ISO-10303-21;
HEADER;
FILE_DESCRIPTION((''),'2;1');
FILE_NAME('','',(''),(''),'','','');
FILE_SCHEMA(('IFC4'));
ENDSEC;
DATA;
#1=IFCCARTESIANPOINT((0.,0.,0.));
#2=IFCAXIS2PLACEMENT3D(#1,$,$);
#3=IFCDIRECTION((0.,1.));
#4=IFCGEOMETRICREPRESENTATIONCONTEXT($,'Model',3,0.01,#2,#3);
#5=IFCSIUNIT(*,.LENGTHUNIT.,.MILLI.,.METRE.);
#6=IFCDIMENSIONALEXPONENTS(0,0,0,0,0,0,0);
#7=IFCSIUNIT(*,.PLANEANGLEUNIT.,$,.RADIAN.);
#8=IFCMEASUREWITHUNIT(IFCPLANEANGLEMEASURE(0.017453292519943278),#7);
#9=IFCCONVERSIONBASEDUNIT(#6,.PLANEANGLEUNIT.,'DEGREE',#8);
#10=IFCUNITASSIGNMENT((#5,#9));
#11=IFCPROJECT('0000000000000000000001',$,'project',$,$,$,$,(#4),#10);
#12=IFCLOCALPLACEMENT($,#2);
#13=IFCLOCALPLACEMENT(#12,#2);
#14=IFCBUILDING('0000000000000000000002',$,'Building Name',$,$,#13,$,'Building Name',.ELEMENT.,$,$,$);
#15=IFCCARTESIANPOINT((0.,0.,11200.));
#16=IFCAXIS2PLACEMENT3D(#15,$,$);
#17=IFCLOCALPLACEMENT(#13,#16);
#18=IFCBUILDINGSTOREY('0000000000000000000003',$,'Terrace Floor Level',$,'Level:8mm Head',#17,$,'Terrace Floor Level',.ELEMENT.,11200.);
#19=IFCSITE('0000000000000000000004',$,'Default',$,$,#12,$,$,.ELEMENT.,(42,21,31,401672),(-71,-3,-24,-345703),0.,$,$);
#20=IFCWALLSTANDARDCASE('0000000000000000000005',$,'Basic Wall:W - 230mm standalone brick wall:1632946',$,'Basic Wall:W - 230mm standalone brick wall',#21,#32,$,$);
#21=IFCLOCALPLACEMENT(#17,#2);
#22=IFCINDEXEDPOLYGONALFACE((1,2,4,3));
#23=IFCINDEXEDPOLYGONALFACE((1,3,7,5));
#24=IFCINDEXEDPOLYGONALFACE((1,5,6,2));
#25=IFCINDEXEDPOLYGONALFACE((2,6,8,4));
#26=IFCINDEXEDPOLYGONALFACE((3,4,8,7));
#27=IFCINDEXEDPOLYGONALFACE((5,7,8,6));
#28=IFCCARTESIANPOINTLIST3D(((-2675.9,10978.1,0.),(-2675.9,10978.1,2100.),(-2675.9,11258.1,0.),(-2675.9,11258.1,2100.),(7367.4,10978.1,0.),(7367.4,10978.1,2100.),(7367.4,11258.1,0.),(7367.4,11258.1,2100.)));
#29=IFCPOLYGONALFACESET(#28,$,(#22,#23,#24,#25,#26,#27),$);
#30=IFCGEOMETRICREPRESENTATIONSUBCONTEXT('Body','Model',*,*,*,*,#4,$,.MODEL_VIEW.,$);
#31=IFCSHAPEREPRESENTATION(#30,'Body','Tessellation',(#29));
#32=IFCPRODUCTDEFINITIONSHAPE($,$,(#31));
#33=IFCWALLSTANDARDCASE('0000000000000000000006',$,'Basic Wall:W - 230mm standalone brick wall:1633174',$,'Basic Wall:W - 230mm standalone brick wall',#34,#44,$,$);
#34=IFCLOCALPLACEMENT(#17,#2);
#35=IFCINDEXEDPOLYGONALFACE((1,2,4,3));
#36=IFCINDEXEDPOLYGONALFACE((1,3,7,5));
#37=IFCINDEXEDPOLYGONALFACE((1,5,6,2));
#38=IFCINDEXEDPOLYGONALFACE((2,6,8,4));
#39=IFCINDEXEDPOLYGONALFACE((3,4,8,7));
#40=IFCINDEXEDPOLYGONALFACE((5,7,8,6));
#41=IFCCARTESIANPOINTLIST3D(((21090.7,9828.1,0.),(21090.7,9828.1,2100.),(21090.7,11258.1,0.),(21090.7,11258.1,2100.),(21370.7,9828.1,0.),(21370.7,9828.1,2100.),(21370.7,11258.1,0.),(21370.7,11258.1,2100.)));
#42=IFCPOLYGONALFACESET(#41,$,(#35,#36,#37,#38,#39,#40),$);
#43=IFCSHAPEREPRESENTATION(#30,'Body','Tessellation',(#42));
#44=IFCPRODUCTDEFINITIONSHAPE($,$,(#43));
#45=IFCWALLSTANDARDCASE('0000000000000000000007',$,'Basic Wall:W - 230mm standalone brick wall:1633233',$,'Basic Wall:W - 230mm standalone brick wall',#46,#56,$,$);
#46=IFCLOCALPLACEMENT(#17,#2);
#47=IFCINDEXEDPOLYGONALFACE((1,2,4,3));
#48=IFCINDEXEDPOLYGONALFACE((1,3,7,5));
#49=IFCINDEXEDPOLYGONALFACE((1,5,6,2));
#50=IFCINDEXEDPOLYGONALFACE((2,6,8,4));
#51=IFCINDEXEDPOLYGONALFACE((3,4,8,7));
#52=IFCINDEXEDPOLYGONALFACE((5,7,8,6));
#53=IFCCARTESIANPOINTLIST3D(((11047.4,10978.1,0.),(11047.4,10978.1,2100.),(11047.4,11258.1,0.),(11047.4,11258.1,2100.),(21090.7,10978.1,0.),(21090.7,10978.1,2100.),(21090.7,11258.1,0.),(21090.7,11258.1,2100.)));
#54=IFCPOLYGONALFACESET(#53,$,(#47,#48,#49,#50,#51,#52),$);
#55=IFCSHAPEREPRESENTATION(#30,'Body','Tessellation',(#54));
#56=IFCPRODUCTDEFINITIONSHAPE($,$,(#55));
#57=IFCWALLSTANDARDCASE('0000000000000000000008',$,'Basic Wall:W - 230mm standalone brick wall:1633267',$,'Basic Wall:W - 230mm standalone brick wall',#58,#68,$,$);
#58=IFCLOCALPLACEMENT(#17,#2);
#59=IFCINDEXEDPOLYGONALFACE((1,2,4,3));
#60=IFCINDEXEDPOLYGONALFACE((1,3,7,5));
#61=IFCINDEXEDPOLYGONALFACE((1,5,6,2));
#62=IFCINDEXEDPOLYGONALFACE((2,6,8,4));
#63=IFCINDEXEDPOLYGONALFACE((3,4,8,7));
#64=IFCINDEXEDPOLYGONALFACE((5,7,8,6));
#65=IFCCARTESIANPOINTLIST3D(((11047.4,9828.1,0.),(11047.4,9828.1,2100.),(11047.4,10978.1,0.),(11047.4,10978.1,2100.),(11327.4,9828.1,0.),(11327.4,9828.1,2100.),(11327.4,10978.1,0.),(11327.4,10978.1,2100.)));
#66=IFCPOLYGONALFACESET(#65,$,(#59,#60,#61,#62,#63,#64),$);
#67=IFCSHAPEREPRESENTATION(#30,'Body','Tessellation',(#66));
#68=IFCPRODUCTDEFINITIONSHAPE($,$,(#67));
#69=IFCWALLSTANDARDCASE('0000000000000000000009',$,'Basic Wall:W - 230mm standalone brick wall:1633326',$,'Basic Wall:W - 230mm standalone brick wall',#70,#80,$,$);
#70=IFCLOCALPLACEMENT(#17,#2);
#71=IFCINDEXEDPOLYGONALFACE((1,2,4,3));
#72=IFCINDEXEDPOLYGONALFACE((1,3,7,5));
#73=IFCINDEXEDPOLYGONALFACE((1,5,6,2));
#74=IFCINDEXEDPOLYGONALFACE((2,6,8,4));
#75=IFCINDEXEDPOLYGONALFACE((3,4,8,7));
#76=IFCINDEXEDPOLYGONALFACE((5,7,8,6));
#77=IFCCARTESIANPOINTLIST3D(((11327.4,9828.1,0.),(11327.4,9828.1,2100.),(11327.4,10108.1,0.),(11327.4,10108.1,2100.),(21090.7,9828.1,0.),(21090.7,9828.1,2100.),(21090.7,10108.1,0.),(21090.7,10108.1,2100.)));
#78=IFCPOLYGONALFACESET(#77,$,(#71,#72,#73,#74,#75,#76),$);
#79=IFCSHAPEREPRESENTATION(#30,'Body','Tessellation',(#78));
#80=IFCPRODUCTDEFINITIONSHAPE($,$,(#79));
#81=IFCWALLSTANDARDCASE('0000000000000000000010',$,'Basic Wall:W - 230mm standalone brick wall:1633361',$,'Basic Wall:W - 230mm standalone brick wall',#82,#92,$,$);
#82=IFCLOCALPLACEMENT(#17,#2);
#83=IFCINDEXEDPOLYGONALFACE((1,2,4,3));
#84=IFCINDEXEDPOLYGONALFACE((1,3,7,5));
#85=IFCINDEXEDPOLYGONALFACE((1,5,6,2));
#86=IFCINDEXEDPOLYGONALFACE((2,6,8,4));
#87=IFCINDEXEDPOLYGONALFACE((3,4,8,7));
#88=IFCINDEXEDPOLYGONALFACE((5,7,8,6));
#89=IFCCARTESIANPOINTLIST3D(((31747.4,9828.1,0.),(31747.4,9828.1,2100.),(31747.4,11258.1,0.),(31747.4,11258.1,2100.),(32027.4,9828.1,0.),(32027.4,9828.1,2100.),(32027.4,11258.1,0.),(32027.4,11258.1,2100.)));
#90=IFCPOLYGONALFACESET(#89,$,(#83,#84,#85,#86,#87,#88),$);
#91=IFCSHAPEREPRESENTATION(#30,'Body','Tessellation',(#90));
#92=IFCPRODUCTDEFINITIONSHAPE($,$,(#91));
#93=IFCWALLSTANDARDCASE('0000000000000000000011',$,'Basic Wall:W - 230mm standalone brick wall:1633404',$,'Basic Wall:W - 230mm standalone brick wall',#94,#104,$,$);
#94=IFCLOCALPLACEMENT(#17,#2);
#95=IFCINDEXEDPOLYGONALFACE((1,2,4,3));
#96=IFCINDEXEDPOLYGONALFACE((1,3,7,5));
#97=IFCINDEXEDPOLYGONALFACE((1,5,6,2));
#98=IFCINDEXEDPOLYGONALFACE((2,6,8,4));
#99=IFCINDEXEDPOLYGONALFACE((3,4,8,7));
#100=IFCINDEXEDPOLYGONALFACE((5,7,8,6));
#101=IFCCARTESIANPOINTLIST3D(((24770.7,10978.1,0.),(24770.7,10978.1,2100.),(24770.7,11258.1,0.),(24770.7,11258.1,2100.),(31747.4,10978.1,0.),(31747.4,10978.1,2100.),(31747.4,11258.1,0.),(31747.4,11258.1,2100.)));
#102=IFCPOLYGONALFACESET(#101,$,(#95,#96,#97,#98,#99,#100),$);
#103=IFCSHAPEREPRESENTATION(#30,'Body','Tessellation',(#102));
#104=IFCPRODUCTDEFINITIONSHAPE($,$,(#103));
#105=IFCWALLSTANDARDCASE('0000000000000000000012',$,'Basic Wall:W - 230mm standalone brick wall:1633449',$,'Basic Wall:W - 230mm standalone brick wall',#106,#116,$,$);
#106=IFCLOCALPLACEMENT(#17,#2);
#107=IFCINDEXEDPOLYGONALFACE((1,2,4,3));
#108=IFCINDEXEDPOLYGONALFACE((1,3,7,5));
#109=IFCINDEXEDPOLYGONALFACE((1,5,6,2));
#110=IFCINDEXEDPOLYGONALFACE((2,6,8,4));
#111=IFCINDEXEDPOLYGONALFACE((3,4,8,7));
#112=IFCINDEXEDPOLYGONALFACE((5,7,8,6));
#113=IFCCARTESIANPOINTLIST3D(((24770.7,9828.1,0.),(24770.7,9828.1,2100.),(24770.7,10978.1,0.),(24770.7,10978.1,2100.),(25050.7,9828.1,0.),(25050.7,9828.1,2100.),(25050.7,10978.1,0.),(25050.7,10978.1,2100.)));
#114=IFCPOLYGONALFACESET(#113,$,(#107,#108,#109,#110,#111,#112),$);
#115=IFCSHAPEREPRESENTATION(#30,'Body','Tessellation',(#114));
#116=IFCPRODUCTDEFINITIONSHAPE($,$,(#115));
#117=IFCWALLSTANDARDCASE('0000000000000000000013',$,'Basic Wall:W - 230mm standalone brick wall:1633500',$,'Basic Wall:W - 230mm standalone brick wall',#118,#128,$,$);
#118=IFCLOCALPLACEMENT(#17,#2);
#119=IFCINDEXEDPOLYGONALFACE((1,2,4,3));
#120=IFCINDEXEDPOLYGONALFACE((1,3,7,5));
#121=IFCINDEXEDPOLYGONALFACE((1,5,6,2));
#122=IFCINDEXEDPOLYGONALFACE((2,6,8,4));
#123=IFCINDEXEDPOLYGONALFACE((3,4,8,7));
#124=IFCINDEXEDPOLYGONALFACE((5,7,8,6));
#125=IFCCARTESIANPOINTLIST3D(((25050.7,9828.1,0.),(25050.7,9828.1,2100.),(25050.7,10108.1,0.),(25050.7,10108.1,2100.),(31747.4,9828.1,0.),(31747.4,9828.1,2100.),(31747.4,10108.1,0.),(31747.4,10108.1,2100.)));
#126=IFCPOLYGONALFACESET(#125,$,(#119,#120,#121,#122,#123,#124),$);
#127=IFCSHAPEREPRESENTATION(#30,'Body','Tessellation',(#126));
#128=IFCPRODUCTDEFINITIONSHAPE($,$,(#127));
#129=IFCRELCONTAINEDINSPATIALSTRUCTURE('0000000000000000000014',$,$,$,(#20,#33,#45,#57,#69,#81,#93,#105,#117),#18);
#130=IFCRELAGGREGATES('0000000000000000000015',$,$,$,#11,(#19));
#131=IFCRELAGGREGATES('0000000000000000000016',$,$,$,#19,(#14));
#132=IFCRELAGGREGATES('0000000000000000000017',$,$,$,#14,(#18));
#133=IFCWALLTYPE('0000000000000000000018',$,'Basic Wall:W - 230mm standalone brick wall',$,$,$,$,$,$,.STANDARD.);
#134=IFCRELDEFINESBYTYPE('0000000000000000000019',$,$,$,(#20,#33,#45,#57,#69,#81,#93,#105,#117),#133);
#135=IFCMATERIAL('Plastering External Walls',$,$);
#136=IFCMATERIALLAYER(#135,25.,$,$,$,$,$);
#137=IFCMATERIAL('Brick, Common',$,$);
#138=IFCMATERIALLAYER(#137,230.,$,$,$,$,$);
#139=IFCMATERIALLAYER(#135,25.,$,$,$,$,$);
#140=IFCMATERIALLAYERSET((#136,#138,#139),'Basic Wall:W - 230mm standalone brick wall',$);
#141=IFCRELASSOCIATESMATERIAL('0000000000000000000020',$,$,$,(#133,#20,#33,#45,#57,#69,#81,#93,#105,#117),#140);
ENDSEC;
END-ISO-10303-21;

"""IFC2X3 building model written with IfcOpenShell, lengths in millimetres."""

from ifc_helpers import new_model, entity, si_unit, converted_unit, direction, frame, frame_2d, origin, place, context, subcontext, project, spatial, rectangle, extrude, material, layer, layer_set, layer_usage, type_object, element, save


model = new_model("IFC2X3")

# Units and contexts
model_context = context("Model", 3, precision=0.01, world=origin(), true_north=direction((0.0, 1.0)))
body_context = subcontext(model_context, "Body", "Model", "MODEL_VIEW")
ifc_project = project(units=[si_unit("LENGTHUNIT", "METRE", prefix="MILLI"), converted_unit("PLANEANGLEUNIT", "DEGREE", entity("IfcPlaneAngleMeasure", 0.017453292519943278), si_unit("PLANEANGLEUNIT", "RADIAN"), dimensions=[0, 0, 0, 0, 0, 0, 0])], contexts=[model_context])

# Site, building, storey
site_placement = place(None, origin())
site = spatial("IfcSite", under=ifc_project, at=site_placement, Name="Default", CompositionType="ELEMENT", RefLatitude=(42, 21, 31, 401672), RefLongitude=(-71, -3, -24, -345703), RefElevation=0.0)
building_placement = place(site_placement, origin())
building = spatial("IfcBuilding", under=site, at=building_placement, Name="Building Name", LongName="Building Name", CompositionType="ELEMENT")
storey_placement = place(building_placement, frame((0.0, 0.0, 11200.0)))
storey = spatial("IfcBuildingStorey", under=building, at=storey_placement, Name="Terrace Floor Level", ObjectType="Level:8mm Head", LongName="Terrace Floor Level", CompositionType="ELEMENT", Elevation=11200.0)

# Walls
ifc_material_1 = material(Name="Plastering External Walls")
ifc_layer_1 = layer(ifc_material_1, 25.0)
ifc_material_2 = material(Name="Brick, Common")
ifc_layer_2 = layer(ifc_material_2, 230.0)
ifc_layer_3 = layer(ifc_material_1, 25.0)
ifc_layer_set = layer_set([ifc_layer_1, ifc_layer_2, ifc_layer_3], Name="Basic Wall:W - 230mm standalone brick wall")
wall_type = type_object("IfcWallType", Name="Basic Wall:W - 230mm standalone brick wall", PredefinedType="STANDARD", material=ifc_layer_set)
ifc_layer_usage_1 = layer_usage(ifc_layer_set, "AXIS2", "NEGATIVE", 140.0)
wall_1_placement = place(storey_placement, frame((7367.4, 11118.1, 0.0), z_axis=(0.0, 0.0, 1.0), x_axis=(-1.0, 0.0, 0.0)))
element("IfcWallStandardCase", 1, at=wall_1_placement, inside=storey, type_object=wall_type, material=ifc_layer_usage_1, Name="Basic Wall:W - 230mm standalone brick wall:1632946", ObjectType="Basic Wall:W - 230mm standalone brick wall", context=body_context, shape_type="SweptSolid", body=[
    extrude(rectangle(XDim=10043.3, YDim=280.0, at=frame_2d((5021.7, 0.0), x_axis=(-1.0, 0.0))), origin(), (0.0, 0.0, 1.0), 2100.0),
])
ifc_layer_usage_2 = layer_usage(ifc_layer_set, "AXIS2", "NEGATIVE", 140.0)
wall_2_placement = place(storey_placement, frame((21230.7, 9828.1, 0.0), z_axis=(0.0, 0.0, 1.0), x_axis=(0.0, 1.0, 0.0)))
element("IfcWallStandardCase", 2, at=wall_2_placement, inside=storey, type_object=wall_type, material=ifc_layer_usage_2, Name="Basic Wall:W - 230mm standalone brick wall:1633174", ObjectType="Basic Wall:W - 230mm standalone brick wall", context=body_context, shape_type="SweptSolid", body=[
    extrude(rectangle(XDim=1430.0, YDim=280.0, at=frame_2d((715.0, 0.0), x_axis=(-1.0, 0.0))), origin(), (0.0, 0.0, 1.0), 2100.0),
])
ifc_layer_usage_3 = layer_usage(ifc_layer_set, "AXIS2", "NEGATIVE", 140.0)
wall_3_placement = place(storey_placement, frame((21090.7, 11118.1, 0.0), z_axis=(0.0, 0.0, 1.0), x_axis=(-1.0, 0.0, 0.0)))
element("IfcWallStandardCase", 3, at=wall_3_placement, inside=storey, type_object=wall_type, material=ifc_layer_usage_3, Name="Basic Wall:W - 230mm standalone brick wall:1633233", ObjectType="Basic Wall:W - 230mm standalone brick wall", context=body_context, shape_type="SweptSolid", body=[
    extrude(rectangle(XDim=10043.3, YDim=280.0, at=frame_2d((5021.7, 0.0), x_axis=(-1.0, 0.0))), origin(), (0.0, 0.0, 1.0), 2100.0),
])
ifc_layer_usage_4 = layer_usage(ifc_layer_set, "AXIS2", "NEGATIVE", 140.0)
wall_4_placement = place(storey_placement, frame((11187.4, 10978.1, 0.0), z_axis=(0.0, 0.0, 1.0), x_axis=(0.0, -1.0, 0.0)))
element("IfcWallStandardCase", 4, at=wall_4_placement, inside=storey, type_object=wall_type, material=ifc_layer_usage_4, Name="Basic Wall:W - 230mm standalone brick wall:1633267", ObjectType="Basic Wall:W - 230mm standalone brick wall", context=body_context, shape_type="SweptSolid", body=[
    extrude(rectangle(XDim=1150.0, YDim=280.0, at=frame_2d((575.0, 0.0), x_axis=(-1.0, 0.0))), origin(), (0.0, 0.0, 1.0), 2100.0),
])
ifc_layer_usage_5 = layer_usage(ifc_layer_set, "AXIS2", "NEGATIVE", 140.0)
wall_5_placement = place(storey_placement, frame((11327.4, 9968.1, 0.0)))
element("IfcWallStandardCase", 5, at=wall_5_placement, inside=storey, type_object=wall_type, material=ifc_layer_usage_5, Name="Basic Wall:W - 230mm standalone brick wall:1633326", ObjectType="Basic Wall:W - 230mm standalone brick wall", context=body_context, shape_type="SweptSolid", body=[
    extrude(rectangle(XDim=9763.3, YDim=280.0, at=frame_2d((4881.7, 0.0), x_axis=(-1.0, 0.0))), origin(), (0.0, 0.0, 1.0), 2100.0),
])
ifc_layer_usage_6 = layer_usage(ifc_layer_set, "AXIS2", "NEGATIVE", 140.0)
wall_6_placement = place(storey_placement, frame((31887.4, 9828.1, 0.0), z_axis=(0.0, 0.0, 1.0), x_axis=(0.0, 1.0, 0.0)))
element("IfcWallStandardCase", 6, at=wall_6_placement, inside=storey, type_object=wall_type, material=ifc_layer_usage_6, Name="Basic Wall:W - 230mm standalone brick wall:1633361", ObjectType="Basic Wall:W - 230mm standalone brick wall", context=body_context, shape_type="SweptSolid", body=[
    extrude(rectangle(XDim=1430.0, YDim=280.0, at=frame_2d((715.0, 0.0), x_axis=(-1.0, 0.0))), origin(), (0.0, 0.0, 1.0), 2100.0),
])
ifc_layer_usage_7 = layer_usage(ifc_layer_set, "AXIS2", "NEGATIVE", 140.0)
wall_7_placement = place(storey_placement, frame((31747.4, 11118.1, 0.0), z_axis=(0.0, 0.0, 1.0), x_axis=(-1.0, 0.0, 0.0)))
element("IfcWallStandardCase", 7, at=wall_7_placement, inside=storey, type_object=wall_type, material=ifc_layer_usage_7, Name="Basic Wall:W - 230mm standalone brick wall:1633404", ObjectType="Basic Wall:W - 230mm standalone brick wall", context=body_context, shape_type="SweptSolid", body=[
    extrude(rectangle(XDim=6976.7, YDim=280.0, at=frame_2d((3488.3, 0.0), x_axis=(-1.0, 0.0))), origin(), (0.0, 0.0, 1.0), 2100.0),
])
ifc_layer_usage_8 = layer_usage(ifc_layer_set, "AXIS2", "NEGATIVE", 140.0)
wall_8_placement = place(storey_placement, frame((24910.7, 10978.1, 0.0), z_axis=(0.0, 0.0, 1.0), x_axis=(0.0, -1.0, 0.0)))
element("IfcWallStandardCase", 8, at=wall_8_placement, inside=storey, type_object=wall_type, material=ifc_layer_usage_8, Name="Basic Wall:W - 230mm standalone brick wall:1633449", ObjectType="Basic Wall:W - 230mm standalone brick wall", context=body_context, shape_type="SweptSolid", body=[
    extrude(rectangle(XDim=1150.0, YDim=280.0, at=frame_2d((575.0, 0.0), x_axis=(-1.0, 0.0))), origin(), (0.0, 0.0, 1.0), 2100.0),
])
ifc_layer_usage_9 = layer_usage(ifc_layer_set, "AXIS2", "NEGATIVE", 140.0)
wall_9_placement = place(storey_placement, frame((25050.7, 9968.1, 0.0)))
element("IfcWallStandardCase", 9, at=wall_9_placement, inside=storey, type_object=wall_type, material=ifc_layer_usage_9, Name="Basic Wall:W - 230mm standalone brick wall:1633500", ObjectType="Basic Wall:W - 230mm standalone brick wall", context=body_context, shape_type="SweptSolid", body=[
    extrude(rectangle(XDim=6696.7, YDim=280.0, at=frame_2d((3348.3, 0.0), x_axis=(-1.0, 0.0))), origin(), (0.0, 0.0, 1.0), 2100.0),
])

save(model, "model.ifc")
